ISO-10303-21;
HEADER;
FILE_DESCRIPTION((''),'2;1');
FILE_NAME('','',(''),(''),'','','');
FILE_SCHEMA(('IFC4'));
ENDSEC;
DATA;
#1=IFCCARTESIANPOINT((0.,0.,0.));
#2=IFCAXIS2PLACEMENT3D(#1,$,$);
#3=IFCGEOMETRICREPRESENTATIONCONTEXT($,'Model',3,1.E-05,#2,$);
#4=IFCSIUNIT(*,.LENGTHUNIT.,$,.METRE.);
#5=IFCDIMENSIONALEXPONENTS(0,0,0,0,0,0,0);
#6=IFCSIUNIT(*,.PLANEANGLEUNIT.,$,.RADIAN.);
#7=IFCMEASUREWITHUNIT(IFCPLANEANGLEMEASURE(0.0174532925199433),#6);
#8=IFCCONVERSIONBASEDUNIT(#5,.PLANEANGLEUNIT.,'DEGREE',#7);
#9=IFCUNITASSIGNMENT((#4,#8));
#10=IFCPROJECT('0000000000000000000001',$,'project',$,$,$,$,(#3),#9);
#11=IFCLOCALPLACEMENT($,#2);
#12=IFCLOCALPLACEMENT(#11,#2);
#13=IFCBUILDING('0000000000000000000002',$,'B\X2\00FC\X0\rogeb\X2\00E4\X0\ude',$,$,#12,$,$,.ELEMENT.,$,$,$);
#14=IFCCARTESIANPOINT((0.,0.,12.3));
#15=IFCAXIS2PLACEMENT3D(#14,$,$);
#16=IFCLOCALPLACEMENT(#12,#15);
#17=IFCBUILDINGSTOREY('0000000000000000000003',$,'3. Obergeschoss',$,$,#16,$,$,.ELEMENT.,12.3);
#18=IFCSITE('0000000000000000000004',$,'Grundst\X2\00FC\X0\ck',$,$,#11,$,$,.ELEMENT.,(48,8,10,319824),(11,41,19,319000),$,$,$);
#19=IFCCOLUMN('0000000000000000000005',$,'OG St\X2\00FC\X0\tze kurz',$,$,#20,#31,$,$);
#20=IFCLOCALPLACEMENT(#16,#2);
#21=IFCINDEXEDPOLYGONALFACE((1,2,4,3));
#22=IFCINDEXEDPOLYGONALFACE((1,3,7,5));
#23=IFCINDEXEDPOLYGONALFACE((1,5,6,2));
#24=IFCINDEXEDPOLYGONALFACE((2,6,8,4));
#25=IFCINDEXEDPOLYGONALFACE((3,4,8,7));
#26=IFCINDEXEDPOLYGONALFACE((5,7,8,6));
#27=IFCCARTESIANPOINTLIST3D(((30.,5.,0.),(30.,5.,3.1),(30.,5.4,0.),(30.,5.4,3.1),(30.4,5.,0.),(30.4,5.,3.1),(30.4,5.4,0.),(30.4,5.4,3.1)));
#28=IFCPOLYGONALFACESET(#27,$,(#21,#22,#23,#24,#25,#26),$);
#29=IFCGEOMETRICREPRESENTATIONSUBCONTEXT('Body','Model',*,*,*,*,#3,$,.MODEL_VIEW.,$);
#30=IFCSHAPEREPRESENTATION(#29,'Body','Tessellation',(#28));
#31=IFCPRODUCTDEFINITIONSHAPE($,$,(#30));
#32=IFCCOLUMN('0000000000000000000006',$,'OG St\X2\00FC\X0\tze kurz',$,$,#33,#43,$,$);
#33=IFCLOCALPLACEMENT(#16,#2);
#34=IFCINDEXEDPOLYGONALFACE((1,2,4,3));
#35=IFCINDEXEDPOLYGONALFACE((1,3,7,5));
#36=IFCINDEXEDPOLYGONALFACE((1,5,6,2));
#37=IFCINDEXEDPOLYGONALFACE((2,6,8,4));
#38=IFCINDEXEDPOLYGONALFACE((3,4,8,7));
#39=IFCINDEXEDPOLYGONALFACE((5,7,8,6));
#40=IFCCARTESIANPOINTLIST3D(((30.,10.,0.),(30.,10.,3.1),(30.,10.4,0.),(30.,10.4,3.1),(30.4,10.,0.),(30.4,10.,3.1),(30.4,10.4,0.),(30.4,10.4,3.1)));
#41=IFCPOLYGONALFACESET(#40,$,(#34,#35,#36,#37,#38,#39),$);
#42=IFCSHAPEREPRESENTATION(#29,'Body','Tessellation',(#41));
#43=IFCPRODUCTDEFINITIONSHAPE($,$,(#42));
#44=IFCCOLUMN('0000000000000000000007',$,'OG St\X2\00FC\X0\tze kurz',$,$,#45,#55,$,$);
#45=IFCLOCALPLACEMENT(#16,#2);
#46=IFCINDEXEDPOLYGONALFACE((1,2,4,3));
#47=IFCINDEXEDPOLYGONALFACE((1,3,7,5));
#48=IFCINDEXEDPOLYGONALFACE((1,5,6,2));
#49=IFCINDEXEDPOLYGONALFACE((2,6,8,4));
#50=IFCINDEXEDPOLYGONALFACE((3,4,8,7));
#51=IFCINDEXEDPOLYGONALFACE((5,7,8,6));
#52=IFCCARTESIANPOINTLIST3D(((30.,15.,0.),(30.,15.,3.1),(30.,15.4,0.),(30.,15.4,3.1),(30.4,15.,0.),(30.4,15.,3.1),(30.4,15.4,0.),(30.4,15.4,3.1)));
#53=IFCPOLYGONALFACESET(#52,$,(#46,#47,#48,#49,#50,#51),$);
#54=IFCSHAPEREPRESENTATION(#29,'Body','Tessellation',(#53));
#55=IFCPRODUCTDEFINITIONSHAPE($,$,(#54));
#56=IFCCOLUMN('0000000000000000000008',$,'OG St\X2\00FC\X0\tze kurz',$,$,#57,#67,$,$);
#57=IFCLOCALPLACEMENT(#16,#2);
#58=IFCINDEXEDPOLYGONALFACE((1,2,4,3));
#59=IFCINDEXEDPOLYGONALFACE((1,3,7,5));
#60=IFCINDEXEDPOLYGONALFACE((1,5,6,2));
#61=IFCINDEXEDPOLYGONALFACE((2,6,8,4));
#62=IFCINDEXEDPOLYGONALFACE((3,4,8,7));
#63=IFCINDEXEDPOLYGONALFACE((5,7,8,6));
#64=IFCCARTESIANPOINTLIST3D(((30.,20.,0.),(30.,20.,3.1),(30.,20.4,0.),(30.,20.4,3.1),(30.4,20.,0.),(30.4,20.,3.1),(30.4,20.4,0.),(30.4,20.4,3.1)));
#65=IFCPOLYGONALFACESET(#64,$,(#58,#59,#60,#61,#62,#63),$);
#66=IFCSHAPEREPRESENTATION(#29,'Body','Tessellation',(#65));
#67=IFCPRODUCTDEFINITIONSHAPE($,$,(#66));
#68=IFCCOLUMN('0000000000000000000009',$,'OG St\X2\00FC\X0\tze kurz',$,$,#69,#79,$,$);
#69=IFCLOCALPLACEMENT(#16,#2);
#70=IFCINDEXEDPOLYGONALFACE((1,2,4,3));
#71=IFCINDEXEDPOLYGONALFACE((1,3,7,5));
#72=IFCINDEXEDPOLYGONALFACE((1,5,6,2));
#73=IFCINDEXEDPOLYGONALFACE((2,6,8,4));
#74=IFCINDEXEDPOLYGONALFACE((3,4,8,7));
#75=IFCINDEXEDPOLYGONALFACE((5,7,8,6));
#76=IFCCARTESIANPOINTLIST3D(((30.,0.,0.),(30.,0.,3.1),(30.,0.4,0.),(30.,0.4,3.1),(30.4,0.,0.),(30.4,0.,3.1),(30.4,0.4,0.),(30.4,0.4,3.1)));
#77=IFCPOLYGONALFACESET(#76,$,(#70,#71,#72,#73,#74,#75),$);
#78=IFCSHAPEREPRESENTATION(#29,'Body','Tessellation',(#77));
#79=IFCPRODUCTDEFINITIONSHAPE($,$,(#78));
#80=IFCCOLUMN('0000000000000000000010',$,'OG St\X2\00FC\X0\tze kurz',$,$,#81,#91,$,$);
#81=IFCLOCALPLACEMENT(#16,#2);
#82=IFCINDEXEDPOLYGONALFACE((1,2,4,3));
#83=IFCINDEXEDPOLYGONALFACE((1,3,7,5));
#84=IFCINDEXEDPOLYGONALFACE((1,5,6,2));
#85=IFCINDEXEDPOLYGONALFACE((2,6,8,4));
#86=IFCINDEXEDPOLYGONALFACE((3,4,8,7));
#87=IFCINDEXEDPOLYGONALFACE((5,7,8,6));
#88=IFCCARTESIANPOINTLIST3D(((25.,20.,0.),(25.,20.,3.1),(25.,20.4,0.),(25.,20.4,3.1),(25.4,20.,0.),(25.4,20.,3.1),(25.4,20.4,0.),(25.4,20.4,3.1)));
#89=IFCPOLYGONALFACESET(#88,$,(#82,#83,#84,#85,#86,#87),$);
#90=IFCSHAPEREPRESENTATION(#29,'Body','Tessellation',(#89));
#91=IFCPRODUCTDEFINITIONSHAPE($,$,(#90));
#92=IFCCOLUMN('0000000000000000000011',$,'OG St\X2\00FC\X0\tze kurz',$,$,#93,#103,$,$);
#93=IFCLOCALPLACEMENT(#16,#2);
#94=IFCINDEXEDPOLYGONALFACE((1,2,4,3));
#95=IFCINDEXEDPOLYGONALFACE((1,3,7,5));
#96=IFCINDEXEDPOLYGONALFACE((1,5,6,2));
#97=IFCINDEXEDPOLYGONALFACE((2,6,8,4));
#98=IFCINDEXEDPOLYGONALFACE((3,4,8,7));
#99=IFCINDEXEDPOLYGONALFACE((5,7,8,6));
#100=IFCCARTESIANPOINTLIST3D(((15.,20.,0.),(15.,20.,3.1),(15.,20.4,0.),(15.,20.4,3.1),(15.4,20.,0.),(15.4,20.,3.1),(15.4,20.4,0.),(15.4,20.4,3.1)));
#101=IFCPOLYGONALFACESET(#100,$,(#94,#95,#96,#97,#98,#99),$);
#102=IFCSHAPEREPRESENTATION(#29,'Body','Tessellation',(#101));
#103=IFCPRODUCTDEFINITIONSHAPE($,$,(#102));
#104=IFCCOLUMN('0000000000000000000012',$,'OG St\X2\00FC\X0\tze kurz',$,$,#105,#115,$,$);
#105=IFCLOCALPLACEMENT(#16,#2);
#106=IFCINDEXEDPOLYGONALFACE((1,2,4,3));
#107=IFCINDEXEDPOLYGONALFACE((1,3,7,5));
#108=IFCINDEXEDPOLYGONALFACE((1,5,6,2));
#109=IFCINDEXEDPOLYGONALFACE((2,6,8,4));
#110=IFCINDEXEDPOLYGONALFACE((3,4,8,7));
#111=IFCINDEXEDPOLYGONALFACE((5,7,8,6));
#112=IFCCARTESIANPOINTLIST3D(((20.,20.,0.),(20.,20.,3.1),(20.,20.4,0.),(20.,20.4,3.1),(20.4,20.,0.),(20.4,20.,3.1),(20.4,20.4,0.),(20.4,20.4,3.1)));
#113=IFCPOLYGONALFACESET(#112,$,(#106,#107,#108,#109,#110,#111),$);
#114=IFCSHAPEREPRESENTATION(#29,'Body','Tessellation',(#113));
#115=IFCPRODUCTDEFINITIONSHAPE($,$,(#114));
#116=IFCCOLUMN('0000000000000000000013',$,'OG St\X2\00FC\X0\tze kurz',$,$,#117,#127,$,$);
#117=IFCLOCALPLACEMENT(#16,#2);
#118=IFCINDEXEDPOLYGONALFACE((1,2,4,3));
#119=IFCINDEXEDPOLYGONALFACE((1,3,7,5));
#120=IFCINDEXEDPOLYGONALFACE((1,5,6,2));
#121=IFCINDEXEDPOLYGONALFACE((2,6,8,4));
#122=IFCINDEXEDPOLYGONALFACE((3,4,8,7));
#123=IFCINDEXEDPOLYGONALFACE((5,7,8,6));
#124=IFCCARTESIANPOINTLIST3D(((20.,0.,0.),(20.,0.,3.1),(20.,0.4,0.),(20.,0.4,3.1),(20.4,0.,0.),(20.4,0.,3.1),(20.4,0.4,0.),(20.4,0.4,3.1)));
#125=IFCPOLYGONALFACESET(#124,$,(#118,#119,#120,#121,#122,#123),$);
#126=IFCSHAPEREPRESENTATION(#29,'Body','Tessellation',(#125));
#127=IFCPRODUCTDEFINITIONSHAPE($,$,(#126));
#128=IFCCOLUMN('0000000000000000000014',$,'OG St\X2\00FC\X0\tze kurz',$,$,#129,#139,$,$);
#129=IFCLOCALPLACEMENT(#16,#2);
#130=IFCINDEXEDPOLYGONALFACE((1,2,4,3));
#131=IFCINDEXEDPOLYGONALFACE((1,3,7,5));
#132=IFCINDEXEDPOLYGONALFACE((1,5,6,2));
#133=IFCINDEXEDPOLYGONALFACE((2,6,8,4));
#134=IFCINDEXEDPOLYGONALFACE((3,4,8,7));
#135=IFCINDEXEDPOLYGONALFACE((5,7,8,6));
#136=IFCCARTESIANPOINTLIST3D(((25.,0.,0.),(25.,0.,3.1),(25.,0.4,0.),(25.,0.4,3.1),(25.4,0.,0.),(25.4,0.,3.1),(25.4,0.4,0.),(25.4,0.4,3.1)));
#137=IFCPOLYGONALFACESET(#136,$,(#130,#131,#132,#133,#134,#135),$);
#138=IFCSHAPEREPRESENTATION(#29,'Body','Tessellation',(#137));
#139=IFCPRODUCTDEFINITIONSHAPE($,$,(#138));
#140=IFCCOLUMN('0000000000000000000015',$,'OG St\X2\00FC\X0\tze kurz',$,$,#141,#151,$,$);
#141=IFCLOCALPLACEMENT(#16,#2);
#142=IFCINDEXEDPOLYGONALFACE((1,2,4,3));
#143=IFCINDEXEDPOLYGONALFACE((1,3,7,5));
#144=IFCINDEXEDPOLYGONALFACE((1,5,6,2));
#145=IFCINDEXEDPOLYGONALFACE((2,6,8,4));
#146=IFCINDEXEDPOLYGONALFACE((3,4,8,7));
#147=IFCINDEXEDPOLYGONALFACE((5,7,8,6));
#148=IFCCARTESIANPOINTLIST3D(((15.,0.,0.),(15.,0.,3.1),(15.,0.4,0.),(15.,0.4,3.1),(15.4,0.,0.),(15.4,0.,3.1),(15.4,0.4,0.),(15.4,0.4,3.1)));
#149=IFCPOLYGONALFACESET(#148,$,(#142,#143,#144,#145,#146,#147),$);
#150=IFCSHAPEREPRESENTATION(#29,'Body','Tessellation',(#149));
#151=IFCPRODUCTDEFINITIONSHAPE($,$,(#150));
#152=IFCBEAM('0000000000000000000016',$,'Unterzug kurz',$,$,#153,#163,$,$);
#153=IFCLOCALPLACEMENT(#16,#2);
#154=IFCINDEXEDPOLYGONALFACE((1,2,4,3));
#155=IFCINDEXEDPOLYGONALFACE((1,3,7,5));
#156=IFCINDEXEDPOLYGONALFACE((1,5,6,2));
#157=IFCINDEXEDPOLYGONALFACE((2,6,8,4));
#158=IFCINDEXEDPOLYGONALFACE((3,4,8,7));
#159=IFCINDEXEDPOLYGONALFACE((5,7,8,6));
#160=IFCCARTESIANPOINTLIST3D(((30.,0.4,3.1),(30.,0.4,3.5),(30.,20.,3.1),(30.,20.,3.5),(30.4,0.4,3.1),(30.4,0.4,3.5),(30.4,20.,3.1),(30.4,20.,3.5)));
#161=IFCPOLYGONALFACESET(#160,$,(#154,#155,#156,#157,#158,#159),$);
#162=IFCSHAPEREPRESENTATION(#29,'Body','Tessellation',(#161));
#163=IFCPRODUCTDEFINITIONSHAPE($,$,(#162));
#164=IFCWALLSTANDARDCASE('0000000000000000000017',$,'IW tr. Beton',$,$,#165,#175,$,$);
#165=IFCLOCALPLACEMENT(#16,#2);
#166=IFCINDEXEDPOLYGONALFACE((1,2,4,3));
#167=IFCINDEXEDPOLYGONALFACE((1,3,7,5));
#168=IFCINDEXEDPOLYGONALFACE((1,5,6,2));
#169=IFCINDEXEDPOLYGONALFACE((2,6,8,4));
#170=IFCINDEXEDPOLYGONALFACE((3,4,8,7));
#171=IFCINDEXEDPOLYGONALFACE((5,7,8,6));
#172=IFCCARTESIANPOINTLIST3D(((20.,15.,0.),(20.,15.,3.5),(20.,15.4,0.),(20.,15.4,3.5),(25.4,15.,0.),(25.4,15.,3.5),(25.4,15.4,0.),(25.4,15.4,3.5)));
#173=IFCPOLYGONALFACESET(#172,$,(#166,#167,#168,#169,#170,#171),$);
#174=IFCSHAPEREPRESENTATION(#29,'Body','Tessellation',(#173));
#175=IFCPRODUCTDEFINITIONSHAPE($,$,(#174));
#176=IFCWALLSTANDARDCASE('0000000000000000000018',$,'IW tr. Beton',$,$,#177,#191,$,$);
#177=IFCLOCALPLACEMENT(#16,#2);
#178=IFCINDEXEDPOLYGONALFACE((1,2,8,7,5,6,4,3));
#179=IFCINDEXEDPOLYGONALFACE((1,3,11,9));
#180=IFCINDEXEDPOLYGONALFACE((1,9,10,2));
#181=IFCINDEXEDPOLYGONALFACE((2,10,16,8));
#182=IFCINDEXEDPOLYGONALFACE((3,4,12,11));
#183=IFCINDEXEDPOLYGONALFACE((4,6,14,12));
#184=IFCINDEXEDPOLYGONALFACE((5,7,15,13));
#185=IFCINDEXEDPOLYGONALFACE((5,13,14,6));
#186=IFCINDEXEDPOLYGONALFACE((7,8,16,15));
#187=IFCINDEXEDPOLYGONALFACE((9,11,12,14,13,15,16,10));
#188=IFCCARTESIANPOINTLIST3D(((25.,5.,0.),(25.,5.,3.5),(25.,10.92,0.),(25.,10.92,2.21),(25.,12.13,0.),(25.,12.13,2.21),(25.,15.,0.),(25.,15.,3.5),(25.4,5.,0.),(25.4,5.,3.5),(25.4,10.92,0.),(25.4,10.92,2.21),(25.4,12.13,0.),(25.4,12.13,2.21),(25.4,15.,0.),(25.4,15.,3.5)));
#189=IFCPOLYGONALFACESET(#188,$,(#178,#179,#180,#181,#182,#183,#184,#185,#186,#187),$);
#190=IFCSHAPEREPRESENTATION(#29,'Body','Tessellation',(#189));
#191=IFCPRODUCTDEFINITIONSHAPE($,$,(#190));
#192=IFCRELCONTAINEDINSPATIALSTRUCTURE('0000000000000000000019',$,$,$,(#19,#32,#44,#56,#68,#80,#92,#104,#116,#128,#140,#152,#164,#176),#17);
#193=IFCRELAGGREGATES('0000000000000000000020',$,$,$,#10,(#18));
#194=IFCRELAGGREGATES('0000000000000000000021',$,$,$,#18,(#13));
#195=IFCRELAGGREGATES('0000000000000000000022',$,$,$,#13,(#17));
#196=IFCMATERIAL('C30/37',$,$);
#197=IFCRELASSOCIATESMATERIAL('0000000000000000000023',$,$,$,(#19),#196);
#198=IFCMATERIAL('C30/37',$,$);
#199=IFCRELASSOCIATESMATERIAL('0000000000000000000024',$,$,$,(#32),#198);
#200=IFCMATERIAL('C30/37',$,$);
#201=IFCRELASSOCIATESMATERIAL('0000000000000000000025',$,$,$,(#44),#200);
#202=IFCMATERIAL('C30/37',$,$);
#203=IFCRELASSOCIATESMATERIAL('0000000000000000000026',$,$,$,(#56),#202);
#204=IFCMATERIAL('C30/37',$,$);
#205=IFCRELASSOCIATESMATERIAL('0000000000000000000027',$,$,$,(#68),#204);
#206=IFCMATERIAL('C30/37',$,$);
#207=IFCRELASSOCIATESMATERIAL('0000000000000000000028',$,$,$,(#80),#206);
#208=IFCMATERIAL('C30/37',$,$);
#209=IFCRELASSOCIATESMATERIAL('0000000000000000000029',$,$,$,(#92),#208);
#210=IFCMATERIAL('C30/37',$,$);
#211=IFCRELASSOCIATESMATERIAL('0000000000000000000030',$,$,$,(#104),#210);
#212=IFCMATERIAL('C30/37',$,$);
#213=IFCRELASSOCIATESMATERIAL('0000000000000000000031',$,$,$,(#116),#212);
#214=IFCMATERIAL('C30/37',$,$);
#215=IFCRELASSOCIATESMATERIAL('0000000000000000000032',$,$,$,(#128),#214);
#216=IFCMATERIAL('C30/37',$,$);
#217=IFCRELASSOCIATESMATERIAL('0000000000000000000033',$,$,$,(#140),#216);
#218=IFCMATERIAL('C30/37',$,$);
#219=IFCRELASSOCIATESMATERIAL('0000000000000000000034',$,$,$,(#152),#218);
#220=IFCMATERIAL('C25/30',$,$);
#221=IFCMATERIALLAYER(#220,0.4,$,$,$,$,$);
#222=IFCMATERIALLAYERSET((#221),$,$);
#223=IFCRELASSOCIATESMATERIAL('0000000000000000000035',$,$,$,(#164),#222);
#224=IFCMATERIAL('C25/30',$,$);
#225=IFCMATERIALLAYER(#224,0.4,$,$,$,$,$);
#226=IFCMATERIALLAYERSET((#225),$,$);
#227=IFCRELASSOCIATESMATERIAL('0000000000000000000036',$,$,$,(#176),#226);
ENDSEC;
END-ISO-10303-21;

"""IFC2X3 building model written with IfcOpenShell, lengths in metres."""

from ifc_helpers import new_model, entity, si_unit, converted_unit, frame, frame_2d, origin, origin_with_axes, place, context, subcontext, project, spatial, polyline, rectangle, outline, extrude, material, layer, layer_set, layer_usage, element, save


model = new_model("IFC2X3")

# Units and contexts
model_context = context("Model", 3, precision=1e-05, world=origin())
body_context = subcontext(model_context, "Body", "Model", "MODEL_VIEW")
ifc_project = project(units=[si_unit("LENGTHUNIT", "METRE"), converted_unit("PLANEANGLEUNIT", "DEGREE", entity("IfcPlaneAngleMeasure", 0.0174532925199433), si_unit("PLANEANGLEUNIT", "RADIAN"), dimensions=[0, 0, 0, 0, 0, 0, 0])], contexts=[model_context])

# Site, building, storey
site_placement = place(None, origin())
site = spatial("IfcSite", under=ifc_project, at=site_placement, Name="Grundstück", CompositionType="ELEMENT", RefLatitude=(48, 8, 10, 319824), RefLongitude=(11, 41, 19, 319000))
building_placement = place(site_placement, origin())
building = spatial("IfcBuilding", under=site, at=building_placement, Name="Bürogebäude", CompositionType="ELEMENT")
storey_placement = place(building_placement, frame((0.0, 0.0, 12.3)))
storey = spatial("IfcBuildingStorey", under=building, at=storey_placement, Name="3. Obergeschoss", CompositionType="ELEMENT", Elevation=12.3)

# Columns
ifc_material_1 = material(Name="C30/37")
column_1_placement = place(storey_placement, frame((30.0, 5.0, 0.0)))
element("IfcColumn", 1, at=column_1_placement, inside=storey, material=ifc_material_1, Name="OG Stütze kurz", context=body_context, shape_type="SweptSolid", body=[
    extrude(rectangle(XDim=0.4, YDim=0.4, at=frame_2d((0.2, 0.2), x_axis=(1.0, 0.0))), origin_with_axes(), (0.0, 0.0, 1.0), 3.1),
])
ifc_material_2 = material(Name="C30/37")
column_2_placement = place(storey_placement, frame((30.0, 10.0, 0.0)))
element("IfcColumn", 2, at=column_2_placement, inside=storey, material=ifc_material_2, Name="OG Stütze kurz", context=body_context, shape_type="SweptSolid", body=[
    extrude(rectangle(XDim=0.4, YDim=0.4, at=frame_2d((0.2, 0.2), x_axis=(1.0, 0.0))), origin_with_axes(), (0.0, 0.0, 1.0), 3.1),
])
ifc_material_3 = material(Name="C30/37")
column_3_placement = place(storey_placement, frame((30.0, 15.0, 0.0)))
element("IfcColumn", 3, at=column_3_placement, inside=storey, material=ifc_material_3, Name="OG Stütze kurz", context=body_context, shape_type="SweptSolid", body=[
    extrude(rectangle(XDim=0.4, YDim=0.4, at=frame_2d((0.2, 0.2), x_axis=(1.0, 0.0))), origin_with_axes(), (0.0, 0.0, 1.0), 3.1),
])
ifc_material_4 = material(Name="C30/37")
column_4_placement = place(storey_placement, frame((30.0, 20.0, 0.0)))
element("IfcColumn", 4, at=column_4_placement, inside=storey, material=ifc_material_4, Name="OG Stütze kurz", context=body_context, shape_type="SweptSolid", body=[
    extrude(rectangle(XDim=0.4, YDim=0.4, at=frame_2d((0.2, 0.2), x_axis=(1.0, 0.0))), origin_with_axes(), (0.0, 0.0, 1.0), 3.1),
])
ifc_material_5 = material(Name="C30/37")
column_5_placement = place(storey_placement, frame((30.0, 0.0, 0.0)))
element("IfcColumn", 5, at=column_5_placement, inside=storey, material=ifc_material_5, Name="OG Stütze kurz", context=body_context, shape_type="SweptSolid", body=[
    extrude(rectangle(XDim=0.4, YDim=0.4, at=frame_2d((0.2, 0.2), x_axis=(1.0, 0.0))), origin_with_axes(), (0.0, 0.0, 1.0), 3.1),
])
ifc_material_6 = material(Name="C30/37")
column_6_placement = place(storey_placement, frame((25.0, 20.0, 0.0)))
element("IfcColumn", 6, at=column_6_placement, inside=storey, material=ifc_material_6, Name="OG Stütze kurz", context=body_context, shape_type="SweptSolid", body=[
    extrude(rectangle(XDim=0.4, YDim=0.4, at=frame_2d((0.2, 0.2), x_axis=(1.0, 0.0))), origin_with_axes(), (0.0, 0.0, 1.0), 3.1),
])
ifc_material_7 = material(Name="C30/37")
column_7_placement = place(storey_placement, frame((15.0, 20.0, 0.0)))
element("IfcColumn", 7, at=column_7_placement, inside=storey, material=ifc_material_7, Name="OG Stütze kurz", context=body_context, shape_type="SweptSolid", body=[
    extrude(rectangle(XDim=0.4, YDim=0.4, at=frame_2d((0.2, 0.2), x_axis=(1.0, 0.0))), origin_with_axes(), (0.0, 0.0, 1.0), 3.1),
])
ifc_material_8 = material(Name="C30/37")
column_8_placement = place(storey_placement, frame((20.0, 20.0, 0.0)))
element("IfcColumn", 8, at=column_8_placement, inside=storey, material=ifc_material_8, Name="OG Stütze kurz", context=body_context, shape_type="SweptSolid", body=[
    extrude(rectangle(XDim=0.4, YDim=0.4, at=frame_2d((0.2, 0.2), x_axis=(1.0, 0.0))), origin_with_axes(), (0.0, 0.0, 1.0), 3.1),
])
ifc_material_9 = material(Name="C30/37")
column_9_placement = place(storey_placement, frame((20.0, 0.0, 0.0)))
element("IfcColumn", 9, at=column_9_placement, inside=storey, material=ifc_material_9, Name="OG Stütze kurz", context=body_context, shape_type="SweptSolid", body=[
    extrude(rectangle(XDim=0.4, YDim=0.4, at=frame_2d((0.2, 0.2), x_axis=(1.0, 0.0))), origin_with_axes(), (0.0, 0.0, 1.0), 3.1),
])
ifc_material_10 = material(Name="C30/37")
column_10_placement = place(storey_placement, frame((25.0, 0.0, 0.0)))
element("IfcColumn", 10, at=column_10_placement, inside=storey, material=ifc_material_10, Name="OG Stütze kurz", context=body_context, shape_type="SweptSolid", body=[
    extrude(rectangle(XDim=0.4, YDim=0.4, at=frame_2d((0.2, 0.2), x_axis=(1.0, 0.0))), origin_with_axes(), (0.0, 0.0, 1.0), 3.1),
])
ifc_material_11 = material(Name="C30/37")
column_11_placement = place(storey_placement, frame((15.0, 0.0, 0.0)))
element("IfcColumn", 11, at=column_11_placement, inside=storey, material=ifc_material_11, Name="OG Stütze kurz", context=body_context, shape_type="SweptSolid", body=[
    extrude(rectangle(XDim=0.4, YDim=0.4, at=frame_2d((0.2, 0.2), x_axis=(1.0, 0.0))), origin_with_axes(), (0.0, 0.0, 1.0), 3.1),
])

# Beam
ifc_material_12 = material(Name="C30/37")
beam_placement = place(storey_placement, frame((30.4, 0.4, 3.1), z_axis=(0.0, 0.0, 1.0), x_axis=(0.0, 1.0, 0.0)))
element("IfcBeam", 12, at=beam_placement, inside=storey, material=ifc_material_12, Name="Unterzug kurz", context=body_context, shape_type="SweptSolid", body=[
    extrude(rectangle(XDim=0.4, YDim=0.4, at=frame_2d((0.2, 0.2), x_axis=(1.0, 0.0))), frame((0.0, 0.0, 0.0), z_axis=(1.0, 0.0, 0.0), x_axis=(0.0, 1.0, 0.0)), (0.0, 0.0, 1.0), 19.6),
])

# Wall
ifc_material_13 = material(Name="C25/30")
ifc_layer_1 = layer(ifc_material_13, 0.4)
ifc_layer_set_1 = layer_set([ifc_layer_1])
ifc_layer_usage_1 = layer_usage(ifc_layer_set_1, "AXIS2", "POSITIVE", -0.2)
wall_1_placement = place(storey_placement, frame((20.0, 15.0, 0.0)))
element("IfcWallStandardCase", 13, at=wall_1_placement, inside=storey, material=ifc_layer_usage_1, Name="IW tr. Beton", context=body_context, shape_type="SweptSolid", body=[
    extrude(rectangle(XDim=5.4, YDim=0.4, at=frame_2d((2.7, 0.2), x_axis=(1.0, 0.0))), origin_with_axes(), (0.0, 0.0, 1.0), 3.5),
])

# Wall, opening
ifc_material_14 = material(Name="C25/30")
ifc_layer_2 = layer(ifc_material_14, 0.4)
ifc_layer_set_2 = layer_set([ifc_layer_2])
ifc_layer_usage_2 = layer_usage(ifc_layer_set_2, "AXIS2", "POSITIVE", -0.2)
wall_2_placement = place(storey_placement, frame((25.0, 15.0, 0.0), z_axis=(0.0, 0.0, 1.0), x_axis=(0.0, -1.0, 0.0)))
wall_2 = element("IfcWallStandardCase", 14, at=wall_2_placement, inside=storey, material=ifc_layer_usage_2, Name="IW tr. Beton", context=body_context, shape_type="SweptSolid", body=[
    extrude(rectangle(XDim=10.0, YDim=0.4, at=frame_2d((5.0, 0.2), x_axis=(1.0, 0.0))), origin_with_axes(), (0.0, 0.0, 1.0), 3.5),
])
opening_1_placement = place(wall_2_placement, frame((2.87, 0.0, 0.0), z_axis=(0.0, 1.0, 0.0), x_axis=(0.0, 0.0, 1.0)))
element("IfcOpeningElement", 15, at=opening_1_placement, cuts=wall_2, ObjectType="Opening", context=body_context, shape_type="SweptSolid", body=[
    extrude(outline(polyline([(0.0, 1.21), (2.21, 1.21), (2.21, 0.0), (0.0, 0.0), (0.0, 1.21)])), origin_with_axes(), (0.0, 0.0, 1.0), 0.4),
])

save(model, "model.ifc")
